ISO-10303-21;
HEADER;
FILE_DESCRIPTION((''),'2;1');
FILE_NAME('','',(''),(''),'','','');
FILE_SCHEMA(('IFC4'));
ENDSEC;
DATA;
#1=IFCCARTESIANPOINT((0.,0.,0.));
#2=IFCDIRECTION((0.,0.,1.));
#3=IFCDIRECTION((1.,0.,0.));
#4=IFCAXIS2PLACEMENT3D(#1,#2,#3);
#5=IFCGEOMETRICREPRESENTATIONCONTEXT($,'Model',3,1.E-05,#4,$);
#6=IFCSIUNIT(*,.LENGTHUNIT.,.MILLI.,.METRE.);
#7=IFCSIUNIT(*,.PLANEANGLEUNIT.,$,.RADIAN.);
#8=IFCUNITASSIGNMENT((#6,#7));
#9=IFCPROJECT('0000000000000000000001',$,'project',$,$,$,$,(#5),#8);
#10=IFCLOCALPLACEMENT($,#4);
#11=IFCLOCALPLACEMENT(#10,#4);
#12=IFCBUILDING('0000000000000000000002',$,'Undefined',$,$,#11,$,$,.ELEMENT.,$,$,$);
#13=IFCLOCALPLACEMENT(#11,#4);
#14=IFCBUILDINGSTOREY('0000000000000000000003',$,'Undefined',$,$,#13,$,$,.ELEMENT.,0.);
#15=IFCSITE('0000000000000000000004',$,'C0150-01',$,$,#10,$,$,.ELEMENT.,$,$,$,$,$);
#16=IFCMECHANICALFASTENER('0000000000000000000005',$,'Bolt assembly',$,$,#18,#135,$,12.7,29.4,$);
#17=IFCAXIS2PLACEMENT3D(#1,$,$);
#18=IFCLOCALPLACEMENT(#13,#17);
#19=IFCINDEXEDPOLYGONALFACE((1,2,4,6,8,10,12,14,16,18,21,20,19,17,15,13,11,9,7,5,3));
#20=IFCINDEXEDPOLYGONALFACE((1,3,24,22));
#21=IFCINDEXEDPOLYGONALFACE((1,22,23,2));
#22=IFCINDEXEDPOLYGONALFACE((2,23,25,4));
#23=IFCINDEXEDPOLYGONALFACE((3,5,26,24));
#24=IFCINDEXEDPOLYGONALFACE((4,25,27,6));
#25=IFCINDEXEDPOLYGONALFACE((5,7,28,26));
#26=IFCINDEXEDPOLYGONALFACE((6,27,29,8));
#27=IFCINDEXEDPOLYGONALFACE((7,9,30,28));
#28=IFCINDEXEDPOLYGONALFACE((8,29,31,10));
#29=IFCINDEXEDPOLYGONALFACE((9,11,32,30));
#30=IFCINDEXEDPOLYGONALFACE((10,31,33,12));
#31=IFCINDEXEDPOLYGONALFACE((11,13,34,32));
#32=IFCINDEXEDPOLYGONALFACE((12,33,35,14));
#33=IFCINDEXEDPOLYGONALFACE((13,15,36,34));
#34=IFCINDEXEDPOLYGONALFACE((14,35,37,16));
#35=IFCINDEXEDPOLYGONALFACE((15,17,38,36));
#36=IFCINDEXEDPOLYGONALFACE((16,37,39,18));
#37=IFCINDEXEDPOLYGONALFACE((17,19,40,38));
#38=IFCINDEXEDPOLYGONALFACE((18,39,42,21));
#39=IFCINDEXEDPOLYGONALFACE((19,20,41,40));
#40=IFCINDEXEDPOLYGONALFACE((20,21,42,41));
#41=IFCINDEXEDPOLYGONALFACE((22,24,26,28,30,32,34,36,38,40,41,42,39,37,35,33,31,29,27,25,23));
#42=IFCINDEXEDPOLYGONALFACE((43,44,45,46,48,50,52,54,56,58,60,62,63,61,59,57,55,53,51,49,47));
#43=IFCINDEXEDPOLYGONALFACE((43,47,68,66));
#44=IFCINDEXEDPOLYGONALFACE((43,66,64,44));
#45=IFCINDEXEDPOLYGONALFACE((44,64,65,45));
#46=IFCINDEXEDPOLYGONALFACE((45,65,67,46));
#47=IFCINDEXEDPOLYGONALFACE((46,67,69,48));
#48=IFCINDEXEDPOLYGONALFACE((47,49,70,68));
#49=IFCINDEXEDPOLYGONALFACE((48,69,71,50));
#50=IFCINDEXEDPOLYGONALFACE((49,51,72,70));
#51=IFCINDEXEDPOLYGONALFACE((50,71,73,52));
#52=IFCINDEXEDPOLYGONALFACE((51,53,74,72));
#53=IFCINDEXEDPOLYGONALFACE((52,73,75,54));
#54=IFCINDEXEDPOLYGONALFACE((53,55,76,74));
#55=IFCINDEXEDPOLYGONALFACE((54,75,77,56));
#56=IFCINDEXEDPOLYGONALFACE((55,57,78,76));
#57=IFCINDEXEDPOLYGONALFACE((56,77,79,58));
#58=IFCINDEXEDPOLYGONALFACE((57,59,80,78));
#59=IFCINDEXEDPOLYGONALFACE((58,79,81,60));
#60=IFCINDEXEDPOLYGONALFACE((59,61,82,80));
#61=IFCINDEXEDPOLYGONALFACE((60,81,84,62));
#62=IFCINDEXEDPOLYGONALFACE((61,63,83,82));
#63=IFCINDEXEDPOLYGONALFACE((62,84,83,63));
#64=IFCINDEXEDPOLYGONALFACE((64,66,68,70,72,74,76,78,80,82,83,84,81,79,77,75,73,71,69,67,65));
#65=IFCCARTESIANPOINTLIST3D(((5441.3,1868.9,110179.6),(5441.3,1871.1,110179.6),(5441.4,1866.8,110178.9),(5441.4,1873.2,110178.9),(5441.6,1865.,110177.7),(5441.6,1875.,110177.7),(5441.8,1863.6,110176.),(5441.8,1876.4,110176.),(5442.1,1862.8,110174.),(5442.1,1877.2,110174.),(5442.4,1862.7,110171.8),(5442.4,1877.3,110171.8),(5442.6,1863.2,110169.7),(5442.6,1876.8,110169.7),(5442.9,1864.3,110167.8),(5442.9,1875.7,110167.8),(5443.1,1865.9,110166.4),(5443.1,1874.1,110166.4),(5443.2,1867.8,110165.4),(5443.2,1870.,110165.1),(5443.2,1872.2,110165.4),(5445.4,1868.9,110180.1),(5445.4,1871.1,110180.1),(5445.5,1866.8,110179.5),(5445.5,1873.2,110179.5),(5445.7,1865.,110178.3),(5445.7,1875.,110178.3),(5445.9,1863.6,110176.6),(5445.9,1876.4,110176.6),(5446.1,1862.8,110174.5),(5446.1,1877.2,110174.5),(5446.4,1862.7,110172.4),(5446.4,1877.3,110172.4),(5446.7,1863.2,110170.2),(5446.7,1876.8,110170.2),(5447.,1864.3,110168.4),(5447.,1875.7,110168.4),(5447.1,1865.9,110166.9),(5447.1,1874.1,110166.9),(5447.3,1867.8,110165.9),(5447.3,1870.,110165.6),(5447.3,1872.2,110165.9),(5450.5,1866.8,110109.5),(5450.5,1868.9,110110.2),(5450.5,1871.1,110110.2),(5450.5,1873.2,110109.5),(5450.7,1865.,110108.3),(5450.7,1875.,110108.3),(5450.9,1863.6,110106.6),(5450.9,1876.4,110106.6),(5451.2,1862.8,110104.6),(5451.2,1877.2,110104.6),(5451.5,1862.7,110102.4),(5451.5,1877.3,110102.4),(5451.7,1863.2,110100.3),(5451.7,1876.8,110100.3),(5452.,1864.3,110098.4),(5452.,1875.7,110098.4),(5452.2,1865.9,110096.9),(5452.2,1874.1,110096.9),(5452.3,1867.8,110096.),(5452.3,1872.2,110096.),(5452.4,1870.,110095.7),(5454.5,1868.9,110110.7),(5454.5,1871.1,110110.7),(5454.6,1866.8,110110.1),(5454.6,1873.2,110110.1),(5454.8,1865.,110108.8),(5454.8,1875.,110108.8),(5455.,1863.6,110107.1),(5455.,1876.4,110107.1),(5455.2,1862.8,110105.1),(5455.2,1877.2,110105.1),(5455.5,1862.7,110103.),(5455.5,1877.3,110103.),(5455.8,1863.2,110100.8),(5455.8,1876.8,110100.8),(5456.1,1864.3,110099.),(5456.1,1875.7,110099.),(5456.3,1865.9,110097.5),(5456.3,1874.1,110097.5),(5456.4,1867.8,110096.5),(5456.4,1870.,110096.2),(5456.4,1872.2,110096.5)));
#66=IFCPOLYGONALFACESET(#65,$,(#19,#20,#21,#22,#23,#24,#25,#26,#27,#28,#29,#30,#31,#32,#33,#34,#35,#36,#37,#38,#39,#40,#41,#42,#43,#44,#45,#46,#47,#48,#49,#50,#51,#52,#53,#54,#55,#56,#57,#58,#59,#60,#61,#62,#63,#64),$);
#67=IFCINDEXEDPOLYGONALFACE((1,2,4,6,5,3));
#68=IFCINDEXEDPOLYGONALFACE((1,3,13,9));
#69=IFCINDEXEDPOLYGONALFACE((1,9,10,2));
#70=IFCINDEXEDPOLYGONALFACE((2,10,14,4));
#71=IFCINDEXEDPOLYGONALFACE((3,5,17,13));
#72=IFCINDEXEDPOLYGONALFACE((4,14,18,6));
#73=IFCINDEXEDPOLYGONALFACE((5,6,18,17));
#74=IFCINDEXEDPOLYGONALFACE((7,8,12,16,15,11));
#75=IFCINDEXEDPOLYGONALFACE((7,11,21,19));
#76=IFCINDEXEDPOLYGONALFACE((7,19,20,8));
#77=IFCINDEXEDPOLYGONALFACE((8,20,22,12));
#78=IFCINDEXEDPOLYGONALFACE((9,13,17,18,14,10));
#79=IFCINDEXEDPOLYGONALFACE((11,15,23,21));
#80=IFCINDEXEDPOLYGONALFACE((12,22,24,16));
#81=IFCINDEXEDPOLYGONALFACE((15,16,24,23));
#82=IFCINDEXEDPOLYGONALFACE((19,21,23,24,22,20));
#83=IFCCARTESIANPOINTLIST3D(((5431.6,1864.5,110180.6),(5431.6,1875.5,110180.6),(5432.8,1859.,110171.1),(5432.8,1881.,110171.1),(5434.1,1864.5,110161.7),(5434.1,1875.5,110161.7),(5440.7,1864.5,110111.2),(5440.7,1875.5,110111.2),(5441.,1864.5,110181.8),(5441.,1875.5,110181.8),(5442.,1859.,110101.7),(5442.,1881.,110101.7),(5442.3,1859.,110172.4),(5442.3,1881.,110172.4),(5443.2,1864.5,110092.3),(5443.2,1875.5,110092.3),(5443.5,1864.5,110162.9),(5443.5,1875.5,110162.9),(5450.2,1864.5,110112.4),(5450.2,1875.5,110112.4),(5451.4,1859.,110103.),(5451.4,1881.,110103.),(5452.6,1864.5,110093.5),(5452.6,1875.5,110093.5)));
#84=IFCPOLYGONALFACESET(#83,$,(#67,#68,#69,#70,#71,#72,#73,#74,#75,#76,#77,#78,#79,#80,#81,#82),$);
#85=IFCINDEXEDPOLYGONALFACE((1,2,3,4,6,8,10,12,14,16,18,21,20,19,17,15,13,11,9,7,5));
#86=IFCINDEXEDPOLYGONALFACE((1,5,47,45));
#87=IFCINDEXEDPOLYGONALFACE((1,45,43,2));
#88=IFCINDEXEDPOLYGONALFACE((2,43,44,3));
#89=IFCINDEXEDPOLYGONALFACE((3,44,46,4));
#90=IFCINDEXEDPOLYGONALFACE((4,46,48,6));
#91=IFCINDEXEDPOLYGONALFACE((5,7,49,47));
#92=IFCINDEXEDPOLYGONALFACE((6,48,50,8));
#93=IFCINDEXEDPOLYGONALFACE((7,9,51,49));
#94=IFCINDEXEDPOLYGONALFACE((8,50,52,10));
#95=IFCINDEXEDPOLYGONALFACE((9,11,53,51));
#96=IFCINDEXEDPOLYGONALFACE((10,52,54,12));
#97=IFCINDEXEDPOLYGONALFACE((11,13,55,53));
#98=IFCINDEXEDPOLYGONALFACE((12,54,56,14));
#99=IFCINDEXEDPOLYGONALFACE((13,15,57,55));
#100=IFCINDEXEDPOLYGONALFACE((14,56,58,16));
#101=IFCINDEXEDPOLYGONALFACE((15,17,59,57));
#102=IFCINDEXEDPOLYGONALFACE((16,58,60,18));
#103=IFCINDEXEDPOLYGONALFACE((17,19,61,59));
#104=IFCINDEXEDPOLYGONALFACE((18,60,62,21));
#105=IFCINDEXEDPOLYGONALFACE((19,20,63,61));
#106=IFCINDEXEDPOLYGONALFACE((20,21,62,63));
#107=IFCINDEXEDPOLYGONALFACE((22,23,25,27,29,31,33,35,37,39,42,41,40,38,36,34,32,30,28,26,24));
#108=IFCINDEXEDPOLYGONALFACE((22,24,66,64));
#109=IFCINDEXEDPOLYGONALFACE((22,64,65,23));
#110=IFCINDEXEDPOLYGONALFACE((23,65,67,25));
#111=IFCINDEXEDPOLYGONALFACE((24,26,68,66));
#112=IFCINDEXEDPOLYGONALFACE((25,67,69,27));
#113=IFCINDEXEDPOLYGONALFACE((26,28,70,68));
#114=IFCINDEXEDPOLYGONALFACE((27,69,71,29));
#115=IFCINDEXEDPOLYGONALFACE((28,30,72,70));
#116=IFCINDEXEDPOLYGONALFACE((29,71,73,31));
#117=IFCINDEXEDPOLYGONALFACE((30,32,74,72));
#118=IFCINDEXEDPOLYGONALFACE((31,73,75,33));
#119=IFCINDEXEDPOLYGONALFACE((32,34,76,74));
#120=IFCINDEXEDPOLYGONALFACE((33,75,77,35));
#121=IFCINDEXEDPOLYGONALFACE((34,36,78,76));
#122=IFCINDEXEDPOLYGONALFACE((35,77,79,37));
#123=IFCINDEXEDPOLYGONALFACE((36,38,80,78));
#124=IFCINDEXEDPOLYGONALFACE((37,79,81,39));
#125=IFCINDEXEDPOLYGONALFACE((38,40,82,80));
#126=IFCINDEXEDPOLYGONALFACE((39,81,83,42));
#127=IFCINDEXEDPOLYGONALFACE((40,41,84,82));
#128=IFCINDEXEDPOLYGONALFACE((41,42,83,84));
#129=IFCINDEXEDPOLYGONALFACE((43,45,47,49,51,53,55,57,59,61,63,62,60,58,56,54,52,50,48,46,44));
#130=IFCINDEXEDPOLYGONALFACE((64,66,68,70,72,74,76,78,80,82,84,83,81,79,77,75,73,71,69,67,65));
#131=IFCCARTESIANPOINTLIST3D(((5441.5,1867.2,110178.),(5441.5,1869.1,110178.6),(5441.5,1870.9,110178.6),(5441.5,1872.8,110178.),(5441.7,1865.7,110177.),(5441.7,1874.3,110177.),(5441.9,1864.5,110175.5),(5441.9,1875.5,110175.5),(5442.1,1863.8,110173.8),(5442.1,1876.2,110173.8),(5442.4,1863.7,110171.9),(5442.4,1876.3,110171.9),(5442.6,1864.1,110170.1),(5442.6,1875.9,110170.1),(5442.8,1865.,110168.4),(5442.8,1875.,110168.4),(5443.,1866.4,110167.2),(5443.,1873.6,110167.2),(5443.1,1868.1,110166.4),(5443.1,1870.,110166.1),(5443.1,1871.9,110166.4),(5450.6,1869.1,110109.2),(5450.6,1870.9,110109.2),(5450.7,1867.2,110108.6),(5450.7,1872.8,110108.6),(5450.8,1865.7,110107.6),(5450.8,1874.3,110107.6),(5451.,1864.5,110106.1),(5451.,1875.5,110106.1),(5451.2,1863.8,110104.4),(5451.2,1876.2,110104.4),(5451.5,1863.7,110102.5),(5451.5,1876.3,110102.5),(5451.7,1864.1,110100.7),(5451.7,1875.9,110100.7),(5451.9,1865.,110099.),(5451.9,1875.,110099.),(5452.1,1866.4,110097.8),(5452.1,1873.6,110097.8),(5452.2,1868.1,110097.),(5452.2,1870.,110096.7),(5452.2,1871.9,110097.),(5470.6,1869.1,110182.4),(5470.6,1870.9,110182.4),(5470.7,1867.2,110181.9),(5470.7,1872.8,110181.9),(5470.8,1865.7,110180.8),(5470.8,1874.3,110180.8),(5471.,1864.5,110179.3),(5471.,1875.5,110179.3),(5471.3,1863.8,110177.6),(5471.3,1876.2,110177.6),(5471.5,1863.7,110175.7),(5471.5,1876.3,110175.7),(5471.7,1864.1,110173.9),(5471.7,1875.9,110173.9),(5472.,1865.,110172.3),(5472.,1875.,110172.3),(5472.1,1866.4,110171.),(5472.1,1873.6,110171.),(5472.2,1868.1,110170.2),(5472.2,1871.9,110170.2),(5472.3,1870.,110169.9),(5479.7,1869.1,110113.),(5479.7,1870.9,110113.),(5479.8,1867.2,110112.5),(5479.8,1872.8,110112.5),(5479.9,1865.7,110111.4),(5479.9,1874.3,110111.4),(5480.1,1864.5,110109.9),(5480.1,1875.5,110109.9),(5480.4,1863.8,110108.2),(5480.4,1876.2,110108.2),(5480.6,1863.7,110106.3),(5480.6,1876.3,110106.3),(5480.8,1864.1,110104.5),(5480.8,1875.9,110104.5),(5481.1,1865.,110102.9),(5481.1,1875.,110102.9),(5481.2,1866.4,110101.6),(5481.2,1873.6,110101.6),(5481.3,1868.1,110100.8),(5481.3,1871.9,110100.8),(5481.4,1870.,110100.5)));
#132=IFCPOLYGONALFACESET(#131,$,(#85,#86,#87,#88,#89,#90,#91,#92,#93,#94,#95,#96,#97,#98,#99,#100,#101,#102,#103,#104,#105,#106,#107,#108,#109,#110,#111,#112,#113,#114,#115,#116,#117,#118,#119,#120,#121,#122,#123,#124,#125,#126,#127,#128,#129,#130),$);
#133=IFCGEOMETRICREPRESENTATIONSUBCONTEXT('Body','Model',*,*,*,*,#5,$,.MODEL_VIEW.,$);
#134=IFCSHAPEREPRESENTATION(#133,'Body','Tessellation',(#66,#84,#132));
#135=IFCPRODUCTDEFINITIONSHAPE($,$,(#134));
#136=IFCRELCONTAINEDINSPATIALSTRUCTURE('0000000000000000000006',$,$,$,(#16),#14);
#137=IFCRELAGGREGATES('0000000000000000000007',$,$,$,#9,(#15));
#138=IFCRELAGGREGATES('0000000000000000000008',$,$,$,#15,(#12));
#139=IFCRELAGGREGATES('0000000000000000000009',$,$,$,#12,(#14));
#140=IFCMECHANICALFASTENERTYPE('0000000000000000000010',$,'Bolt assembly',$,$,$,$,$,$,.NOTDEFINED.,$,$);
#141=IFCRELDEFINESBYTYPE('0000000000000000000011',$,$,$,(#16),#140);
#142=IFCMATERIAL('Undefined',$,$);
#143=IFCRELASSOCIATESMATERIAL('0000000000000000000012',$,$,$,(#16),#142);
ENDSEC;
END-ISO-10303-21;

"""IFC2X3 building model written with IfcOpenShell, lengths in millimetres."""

from ifc_helpers import new_model, si_unit, frame, origin_with_axes, origin_2d_with_axis, place, context, subcontext, project, spatial, polyline, circle, outline, extrude, source, transform, mapped, material, type_object, element, save


model = new_model("IFC2X3")

# Units and contexts
model_context = context("Model", 3, precision=1e-05, world=origin_with_axes())
body_context = subcontext(model_context, "Body", "Model", "MODEL_VIEW")
ifc_project = project(units=[si_unit("LENGTHUNIT", "METRE", prefix="MILLI"), si_unit("PLANEANGLEUNIT", "RADIAN")], contexts=[model_context])

# Site, building, storey
site_placement = place(None, origin_with_axes())
site = spatial("IfcSite", under=ifc_project, at=site_placement, Name="C0150-01", CompositionType="ELEMENT")
building_placement = place(site_placement, origin_with_axes())
building = spatial("IfcBuilding", under=site, at=building_placement, Name="Undefined", CompositionType="ELEMENT")
storey_placement = place(building_placement, origin_with_axes())
storey = spatial("IfcBuildingStorey", under=building, at=storey_placement, Name="Undefined", CompositionType="ELEMENT", Elevation=0.0)

# Mechanical fastener
ifc_material_1 = material(Name="Undefined")
mechanical_fastener_type = type_object("IfcMechanicalFastenerType", Name="Bolt assembly")
shared_shape_1 = source(origin_with_axes(), body_context, "Body", "SweptSolid", [
    extrude(circle(Radius=7.3, at=origin_2d_with_axis()), frame((0.0, 0.0, 0.0), z_axis=(0.0, 1.0, 0.0), x_axis=(1.0, 0.0, 0.0)), (0.0, 0.0, 1.0), 4.1),
    extrude(outline(polyline([(9.5, -5.5), (9.5, 5.5), (0.0, 11.0), (-9.5, 5.5), (-9.5, -5.5), (0.0, -11.0), (9.5, -5.5)])), frame((0.0, -9.5, 0.0), z_axis=(0.0, 1.0, 0.0), x_axis=(1.0, 0.0, 0.0)), (0.0, 0.0, 1.0), 9.5),
    extrude(circle(Radius=6.3, at=origin_2d_with_axis()), frame((0.0, 0.0, 0.0), z_axis=(0.0, 1.0, 0.0), x_axis=(1.0, 0.0, 0.0)), (0.0, 0.0, 1.0), 29.4),
])
for number, where, z_axis, x_axis, name in (
    (1, (5442.3, 1870.0, 110172.4), (0.0, -1.0, 0.0), (0.130054, 0.0, -0.991507), "Bolt assembly"),
):
    element("IfcMechanicalFastener", number, at=place(storey_placement, frame(where, z_axis=z_axis, x_axis=x_axis)), inside=storey, type_object=mechanical_fastener_type, material=ifc_material_1, Name=name, NominalDiameter=12.7, NominalLength=29.4, context=body_context, shape_type="MappedRepresentation", body=[
        mapped(shared_shape_1, transform((0.0, 0.0, 0.0))),
        mapped(shared_shape_1, transform((70.0, 0.0, 0.0))),
    ])

save(model, "model.ifc")
